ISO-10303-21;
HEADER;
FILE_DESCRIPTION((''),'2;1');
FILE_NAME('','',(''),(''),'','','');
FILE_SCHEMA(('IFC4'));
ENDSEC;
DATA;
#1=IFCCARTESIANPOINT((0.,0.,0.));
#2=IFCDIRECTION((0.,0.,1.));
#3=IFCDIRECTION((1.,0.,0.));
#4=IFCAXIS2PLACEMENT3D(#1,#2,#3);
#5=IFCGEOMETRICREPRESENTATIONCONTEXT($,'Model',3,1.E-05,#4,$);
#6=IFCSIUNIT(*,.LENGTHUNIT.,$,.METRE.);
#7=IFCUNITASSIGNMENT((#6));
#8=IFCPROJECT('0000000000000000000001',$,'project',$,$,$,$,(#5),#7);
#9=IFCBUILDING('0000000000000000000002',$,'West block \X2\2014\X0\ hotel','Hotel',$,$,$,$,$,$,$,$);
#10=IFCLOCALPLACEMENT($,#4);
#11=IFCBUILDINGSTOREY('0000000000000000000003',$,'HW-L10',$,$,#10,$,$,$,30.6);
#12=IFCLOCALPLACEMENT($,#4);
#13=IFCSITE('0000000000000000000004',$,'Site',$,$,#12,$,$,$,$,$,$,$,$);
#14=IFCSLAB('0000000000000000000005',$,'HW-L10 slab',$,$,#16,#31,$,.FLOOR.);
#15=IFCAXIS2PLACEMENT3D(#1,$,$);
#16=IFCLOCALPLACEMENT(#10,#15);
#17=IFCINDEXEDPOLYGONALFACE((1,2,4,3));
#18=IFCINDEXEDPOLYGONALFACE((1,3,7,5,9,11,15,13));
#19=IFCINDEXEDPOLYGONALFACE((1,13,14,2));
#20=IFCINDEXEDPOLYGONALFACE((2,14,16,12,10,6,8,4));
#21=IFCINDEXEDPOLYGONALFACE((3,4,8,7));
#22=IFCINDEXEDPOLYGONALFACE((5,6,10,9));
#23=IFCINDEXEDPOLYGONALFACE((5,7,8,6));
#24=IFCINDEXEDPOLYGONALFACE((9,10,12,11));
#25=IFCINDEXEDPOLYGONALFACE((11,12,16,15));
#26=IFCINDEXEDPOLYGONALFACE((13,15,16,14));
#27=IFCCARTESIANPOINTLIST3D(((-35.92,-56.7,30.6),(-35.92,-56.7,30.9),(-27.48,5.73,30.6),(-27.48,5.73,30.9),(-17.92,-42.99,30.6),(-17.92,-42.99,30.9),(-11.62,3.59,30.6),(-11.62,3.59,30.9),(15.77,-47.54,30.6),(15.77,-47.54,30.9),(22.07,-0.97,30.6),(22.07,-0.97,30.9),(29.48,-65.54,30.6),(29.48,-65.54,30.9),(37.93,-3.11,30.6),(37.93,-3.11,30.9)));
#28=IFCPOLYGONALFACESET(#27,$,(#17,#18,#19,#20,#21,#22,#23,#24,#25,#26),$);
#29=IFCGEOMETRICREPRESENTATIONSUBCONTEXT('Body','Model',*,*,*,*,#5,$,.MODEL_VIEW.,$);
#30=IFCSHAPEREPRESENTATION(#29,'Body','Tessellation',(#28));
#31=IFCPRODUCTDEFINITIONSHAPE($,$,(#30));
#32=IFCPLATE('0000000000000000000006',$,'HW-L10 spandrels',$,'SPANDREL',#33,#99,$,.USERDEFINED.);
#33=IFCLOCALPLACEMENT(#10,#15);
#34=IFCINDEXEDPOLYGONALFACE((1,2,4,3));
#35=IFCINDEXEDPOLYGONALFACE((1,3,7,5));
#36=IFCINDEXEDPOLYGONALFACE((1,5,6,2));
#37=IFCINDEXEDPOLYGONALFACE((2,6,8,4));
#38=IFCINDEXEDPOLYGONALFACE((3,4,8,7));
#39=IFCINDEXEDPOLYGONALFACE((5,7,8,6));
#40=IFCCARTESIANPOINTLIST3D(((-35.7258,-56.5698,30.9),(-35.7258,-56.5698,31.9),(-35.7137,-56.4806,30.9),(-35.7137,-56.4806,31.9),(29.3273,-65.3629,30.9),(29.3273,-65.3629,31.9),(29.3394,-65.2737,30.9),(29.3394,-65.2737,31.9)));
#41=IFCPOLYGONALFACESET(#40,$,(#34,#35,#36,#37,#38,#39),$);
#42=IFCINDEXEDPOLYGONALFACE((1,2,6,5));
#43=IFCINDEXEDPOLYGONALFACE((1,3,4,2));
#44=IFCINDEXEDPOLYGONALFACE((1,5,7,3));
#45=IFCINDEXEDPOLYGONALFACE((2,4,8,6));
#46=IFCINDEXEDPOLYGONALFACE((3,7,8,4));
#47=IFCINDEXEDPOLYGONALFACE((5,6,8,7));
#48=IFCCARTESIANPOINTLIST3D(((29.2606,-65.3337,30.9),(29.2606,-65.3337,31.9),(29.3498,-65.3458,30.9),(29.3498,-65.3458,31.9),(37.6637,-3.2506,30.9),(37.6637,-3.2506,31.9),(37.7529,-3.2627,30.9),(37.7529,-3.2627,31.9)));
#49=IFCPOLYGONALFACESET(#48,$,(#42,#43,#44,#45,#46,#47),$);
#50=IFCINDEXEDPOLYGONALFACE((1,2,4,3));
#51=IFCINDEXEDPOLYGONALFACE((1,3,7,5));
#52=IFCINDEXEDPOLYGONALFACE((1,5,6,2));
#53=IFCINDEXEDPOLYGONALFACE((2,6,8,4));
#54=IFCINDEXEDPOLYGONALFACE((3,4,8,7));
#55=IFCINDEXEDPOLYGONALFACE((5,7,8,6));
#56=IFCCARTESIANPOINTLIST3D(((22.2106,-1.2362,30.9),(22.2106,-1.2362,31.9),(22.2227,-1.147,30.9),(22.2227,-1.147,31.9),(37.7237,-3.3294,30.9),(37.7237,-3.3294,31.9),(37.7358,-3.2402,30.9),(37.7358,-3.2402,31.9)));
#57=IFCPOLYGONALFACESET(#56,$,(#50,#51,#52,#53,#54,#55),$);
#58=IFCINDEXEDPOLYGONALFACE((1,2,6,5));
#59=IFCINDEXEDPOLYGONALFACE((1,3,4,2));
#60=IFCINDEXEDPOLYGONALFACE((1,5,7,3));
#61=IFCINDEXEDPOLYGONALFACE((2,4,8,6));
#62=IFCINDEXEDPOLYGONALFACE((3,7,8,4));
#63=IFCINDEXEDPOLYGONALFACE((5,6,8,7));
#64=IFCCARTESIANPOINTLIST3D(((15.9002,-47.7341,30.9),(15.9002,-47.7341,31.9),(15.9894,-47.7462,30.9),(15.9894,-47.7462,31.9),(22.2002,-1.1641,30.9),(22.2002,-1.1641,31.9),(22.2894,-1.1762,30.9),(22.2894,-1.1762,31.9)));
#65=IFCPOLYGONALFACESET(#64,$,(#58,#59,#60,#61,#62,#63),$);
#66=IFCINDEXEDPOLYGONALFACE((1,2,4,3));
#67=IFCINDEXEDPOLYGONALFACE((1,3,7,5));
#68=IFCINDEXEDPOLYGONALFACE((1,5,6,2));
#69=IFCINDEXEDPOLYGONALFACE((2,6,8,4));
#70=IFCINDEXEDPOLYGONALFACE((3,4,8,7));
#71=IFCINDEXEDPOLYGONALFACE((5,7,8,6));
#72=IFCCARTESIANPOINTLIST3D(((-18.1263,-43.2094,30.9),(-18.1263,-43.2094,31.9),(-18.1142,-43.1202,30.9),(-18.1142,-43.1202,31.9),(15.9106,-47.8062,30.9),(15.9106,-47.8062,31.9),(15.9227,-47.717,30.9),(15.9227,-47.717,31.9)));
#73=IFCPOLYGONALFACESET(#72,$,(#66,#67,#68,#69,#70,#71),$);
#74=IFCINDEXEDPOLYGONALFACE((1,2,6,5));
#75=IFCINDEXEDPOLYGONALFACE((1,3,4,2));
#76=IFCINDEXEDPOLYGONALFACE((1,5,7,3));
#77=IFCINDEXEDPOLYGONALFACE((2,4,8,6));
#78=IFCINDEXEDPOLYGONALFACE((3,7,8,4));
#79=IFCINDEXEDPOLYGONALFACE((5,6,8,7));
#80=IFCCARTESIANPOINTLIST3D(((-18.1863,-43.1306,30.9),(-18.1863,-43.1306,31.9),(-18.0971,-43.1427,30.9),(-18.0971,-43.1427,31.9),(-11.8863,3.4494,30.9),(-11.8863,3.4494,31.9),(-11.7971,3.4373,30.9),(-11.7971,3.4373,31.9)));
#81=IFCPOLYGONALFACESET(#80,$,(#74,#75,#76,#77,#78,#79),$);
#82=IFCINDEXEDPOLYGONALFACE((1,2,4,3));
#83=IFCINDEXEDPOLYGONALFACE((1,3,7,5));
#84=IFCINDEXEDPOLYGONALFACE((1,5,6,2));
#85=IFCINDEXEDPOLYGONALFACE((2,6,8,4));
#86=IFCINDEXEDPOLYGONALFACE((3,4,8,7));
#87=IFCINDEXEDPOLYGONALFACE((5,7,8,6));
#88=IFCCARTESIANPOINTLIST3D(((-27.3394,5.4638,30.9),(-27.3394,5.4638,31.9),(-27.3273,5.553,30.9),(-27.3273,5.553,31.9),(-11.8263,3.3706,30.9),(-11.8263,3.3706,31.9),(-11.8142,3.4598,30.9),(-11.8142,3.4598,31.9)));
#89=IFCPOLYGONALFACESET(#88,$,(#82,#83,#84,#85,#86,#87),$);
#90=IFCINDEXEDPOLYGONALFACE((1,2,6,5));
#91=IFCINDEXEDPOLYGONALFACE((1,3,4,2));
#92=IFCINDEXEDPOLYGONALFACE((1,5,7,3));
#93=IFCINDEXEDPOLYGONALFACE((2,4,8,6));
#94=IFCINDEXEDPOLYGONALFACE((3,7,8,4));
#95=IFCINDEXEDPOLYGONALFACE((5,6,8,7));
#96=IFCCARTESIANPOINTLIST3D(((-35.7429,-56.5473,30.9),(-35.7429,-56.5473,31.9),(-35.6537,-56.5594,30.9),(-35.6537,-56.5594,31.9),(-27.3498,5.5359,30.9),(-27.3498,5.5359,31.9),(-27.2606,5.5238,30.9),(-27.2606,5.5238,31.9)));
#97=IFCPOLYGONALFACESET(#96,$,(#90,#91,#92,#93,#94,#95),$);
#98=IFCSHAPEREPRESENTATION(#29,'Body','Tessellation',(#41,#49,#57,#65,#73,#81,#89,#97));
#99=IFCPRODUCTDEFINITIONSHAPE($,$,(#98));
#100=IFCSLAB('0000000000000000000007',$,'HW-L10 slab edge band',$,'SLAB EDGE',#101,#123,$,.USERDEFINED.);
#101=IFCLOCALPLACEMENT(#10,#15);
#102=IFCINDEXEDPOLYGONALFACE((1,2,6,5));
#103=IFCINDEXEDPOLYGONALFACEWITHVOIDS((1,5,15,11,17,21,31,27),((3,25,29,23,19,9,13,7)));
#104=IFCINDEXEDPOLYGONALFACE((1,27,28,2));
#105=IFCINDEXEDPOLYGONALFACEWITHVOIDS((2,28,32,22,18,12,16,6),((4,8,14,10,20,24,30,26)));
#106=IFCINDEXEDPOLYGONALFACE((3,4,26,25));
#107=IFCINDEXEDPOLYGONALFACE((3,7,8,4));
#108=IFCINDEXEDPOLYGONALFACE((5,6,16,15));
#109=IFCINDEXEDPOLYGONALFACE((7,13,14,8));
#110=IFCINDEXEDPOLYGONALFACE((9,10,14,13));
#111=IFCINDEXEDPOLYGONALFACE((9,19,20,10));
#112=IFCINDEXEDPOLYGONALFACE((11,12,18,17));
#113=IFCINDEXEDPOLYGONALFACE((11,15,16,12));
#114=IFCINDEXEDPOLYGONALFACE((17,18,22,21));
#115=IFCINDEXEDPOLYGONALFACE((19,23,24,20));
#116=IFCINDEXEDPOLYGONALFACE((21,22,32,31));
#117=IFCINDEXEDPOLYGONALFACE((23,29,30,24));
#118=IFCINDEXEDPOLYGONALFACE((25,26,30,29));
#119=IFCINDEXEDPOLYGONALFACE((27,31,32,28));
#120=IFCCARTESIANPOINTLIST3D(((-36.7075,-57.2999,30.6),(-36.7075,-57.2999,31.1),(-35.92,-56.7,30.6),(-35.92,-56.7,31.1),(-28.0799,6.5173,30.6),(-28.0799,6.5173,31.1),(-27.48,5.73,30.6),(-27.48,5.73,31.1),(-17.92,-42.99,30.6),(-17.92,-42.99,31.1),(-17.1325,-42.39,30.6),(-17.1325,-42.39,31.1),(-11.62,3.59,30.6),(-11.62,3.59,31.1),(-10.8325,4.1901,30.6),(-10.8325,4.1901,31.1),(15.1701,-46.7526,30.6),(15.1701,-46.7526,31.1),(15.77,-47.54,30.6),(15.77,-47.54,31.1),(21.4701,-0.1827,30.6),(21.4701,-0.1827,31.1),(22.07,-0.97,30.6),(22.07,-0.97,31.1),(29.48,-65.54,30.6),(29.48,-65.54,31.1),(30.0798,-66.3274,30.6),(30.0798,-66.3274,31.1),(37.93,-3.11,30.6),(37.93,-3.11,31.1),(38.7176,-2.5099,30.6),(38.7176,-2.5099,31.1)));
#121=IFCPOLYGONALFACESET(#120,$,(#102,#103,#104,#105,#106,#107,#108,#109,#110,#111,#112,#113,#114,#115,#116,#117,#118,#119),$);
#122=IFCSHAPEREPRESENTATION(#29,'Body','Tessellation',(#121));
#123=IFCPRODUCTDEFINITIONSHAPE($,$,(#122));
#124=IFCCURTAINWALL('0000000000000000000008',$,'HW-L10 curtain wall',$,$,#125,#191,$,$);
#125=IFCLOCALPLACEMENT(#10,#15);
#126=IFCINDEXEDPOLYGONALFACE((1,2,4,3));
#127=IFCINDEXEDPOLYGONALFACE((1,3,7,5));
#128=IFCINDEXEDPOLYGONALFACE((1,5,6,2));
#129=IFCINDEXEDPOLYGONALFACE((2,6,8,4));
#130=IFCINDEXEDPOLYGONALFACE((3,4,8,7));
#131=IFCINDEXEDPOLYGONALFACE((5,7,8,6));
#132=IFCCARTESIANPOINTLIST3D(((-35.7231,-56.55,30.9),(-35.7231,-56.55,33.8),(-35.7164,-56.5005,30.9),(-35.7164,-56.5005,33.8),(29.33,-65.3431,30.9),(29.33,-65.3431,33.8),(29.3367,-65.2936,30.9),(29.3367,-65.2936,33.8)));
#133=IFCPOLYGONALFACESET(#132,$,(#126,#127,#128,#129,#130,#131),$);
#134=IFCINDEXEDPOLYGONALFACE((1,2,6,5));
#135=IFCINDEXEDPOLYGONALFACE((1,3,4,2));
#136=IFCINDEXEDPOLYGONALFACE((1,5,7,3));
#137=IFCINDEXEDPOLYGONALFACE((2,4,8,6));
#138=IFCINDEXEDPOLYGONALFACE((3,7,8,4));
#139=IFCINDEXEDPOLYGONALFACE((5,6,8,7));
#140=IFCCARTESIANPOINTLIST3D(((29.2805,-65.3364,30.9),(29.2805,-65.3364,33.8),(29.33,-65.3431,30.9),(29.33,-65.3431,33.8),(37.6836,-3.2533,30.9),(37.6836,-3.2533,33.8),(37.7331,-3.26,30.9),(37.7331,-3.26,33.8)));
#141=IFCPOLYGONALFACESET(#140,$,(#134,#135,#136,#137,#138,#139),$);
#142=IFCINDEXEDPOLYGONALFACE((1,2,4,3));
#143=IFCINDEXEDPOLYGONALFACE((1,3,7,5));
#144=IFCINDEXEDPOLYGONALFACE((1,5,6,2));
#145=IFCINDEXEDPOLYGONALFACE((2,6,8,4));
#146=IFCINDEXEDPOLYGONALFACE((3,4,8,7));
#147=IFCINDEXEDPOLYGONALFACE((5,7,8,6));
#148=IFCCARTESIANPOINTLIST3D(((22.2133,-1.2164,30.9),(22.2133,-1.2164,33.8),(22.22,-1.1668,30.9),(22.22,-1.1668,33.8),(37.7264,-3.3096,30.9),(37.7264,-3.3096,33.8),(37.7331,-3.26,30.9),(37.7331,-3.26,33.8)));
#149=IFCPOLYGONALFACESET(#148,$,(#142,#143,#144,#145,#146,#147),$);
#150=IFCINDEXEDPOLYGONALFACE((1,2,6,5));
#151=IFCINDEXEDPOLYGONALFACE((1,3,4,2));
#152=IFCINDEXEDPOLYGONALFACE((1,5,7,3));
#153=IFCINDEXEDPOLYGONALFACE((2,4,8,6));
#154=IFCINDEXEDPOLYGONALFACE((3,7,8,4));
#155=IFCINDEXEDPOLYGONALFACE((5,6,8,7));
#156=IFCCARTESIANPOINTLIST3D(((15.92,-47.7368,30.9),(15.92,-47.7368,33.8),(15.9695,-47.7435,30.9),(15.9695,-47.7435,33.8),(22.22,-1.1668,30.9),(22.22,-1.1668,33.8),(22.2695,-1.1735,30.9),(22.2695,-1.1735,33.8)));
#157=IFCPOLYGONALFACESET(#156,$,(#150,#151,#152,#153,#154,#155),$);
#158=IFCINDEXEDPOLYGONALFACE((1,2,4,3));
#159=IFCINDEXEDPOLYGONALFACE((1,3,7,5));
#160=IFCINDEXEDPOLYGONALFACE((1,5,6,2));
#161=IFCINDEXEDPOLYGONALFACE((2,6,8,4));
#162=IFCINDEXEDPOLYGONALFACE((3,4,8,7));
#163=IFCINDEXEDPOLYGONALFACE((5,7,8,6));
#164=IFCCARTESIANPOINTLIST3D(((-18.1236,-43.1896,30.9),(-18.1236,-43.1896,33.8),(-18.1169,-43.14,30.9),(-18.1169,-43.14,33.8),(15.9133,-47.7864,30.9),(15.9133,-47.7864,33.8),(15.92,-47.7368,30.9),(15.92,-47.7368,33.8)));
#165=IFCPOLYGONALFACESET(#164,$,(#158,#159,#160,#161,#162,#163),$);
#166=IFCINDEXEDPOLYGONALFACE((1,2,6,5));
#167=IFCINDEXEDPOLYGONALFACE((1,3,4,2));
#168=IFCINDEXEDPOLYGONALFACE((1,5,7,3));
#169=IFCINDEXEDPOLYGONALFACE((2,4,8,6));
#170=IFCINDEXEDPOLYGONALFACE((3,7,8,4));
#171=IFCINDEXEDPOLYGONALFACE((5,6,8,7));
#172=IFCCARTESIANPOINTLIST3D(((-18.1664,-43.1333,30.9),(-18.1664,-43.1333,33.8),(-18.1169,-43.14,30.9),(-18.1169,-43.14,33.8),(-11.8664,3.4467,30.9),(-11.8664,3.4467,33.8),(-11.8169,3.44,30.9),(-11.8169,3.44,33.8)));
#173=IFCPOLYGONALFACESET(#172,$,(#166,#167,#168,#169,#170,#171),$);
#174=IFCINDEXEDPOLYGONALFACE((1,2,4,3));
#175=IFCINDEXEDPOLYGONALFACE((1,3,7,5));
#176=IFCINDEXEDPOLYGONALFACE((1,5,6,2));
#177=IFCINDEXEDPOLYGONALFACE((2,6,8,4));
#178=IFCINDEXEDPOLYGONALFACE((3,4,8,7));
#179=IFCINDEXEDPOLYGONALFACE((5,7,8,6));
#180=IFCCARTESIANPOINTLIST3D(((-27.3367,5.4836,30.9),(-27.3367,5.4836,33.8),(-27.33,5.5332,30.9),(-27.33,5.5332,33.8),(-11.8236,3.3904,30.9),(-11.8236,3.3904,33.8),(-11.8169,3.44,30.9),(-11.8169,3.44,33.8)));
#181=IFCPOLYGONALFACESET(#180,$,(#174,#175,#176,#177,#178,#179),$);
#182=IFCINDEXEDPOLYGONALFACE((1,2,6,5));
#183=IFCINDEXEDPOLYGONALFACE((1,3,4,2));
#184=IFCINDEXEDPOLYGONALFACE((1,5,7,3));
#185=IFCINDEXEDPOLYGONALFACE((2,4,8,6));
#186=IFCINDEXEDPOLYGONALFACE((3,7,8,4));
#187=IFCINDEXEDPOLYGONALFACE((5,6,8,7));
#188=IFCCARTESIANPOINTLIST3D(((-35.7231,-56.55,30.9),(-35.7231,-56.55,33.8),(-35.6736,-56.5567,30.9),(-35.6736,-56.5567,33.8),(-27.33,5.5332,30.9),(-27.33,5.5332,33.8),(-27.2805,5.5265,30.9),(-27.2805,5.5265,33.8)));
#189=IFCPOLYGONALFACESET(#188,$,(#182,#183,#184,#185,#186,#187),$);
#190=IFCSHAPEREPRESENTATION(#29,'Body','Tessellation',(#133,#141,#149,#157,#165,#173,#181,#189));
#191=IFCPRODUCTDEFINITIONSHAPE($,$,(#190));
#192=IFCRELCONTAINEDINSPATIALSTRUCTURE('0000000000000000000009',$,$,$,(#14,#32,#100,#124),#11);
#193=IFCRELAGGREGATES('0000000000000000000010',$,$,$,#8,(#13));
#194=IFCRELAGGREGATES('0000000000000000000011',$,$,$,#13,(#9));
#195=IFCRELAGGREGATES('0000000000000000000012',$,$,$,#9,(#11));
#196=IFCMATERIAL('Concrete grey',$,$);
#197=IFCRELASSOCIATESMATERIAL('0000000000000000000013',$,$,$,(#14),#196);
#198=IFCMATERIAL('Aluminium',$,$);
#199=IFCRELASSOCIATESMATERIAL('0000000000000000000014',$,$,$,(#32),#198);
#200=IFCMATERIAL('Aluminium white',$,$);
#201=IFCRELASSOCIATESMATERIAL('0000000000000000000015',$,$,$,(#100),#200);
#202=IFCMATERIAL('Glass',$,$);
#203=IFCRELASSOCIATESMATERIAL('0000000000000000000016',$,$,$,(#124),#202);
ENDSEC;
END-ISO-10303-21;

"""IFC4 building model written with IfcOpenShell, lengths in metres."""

from ifc_helpers import new_model, si_unit, frame, origin_with_axes, place, context, subcontext, project, spatial, polyline, outline, extrude, material, element, save


model = new_model("IFC4")

# Units and contexts
model_context = context("Model", 3, precision=1e-05, world=origin_with_axes())
body_context = subcontext(model_context, "Body", "Model", "MODEL_VIEW")
ifc_project = project(units=[si_unit("LENGTHUNIT", "METRE")], contexts=[model_context])

# Site, building, storey
site_placement = place(None, origin_with_axes())
site = spatial("IfcSite", under=ifc_project, at=site_placement, Name="Site")
building = spatial("IfcBuilding", under=site, Name="West block — hotel", Description="Hotel")
storey_placement = place(None, origin_with_axes())
storey = spatial("IfcBuildingStorey", under=building, at=storey_placement, Name="HW-L10", Elevation=30.6)

# Shared definitions
ifc_material_1 = material(Name="Aluminium")

# Slab
ifc_material_2 = material(Name="Concrete grey")
slab_1_placement = place(storey_placement, origin_with_axes())
element("IfcSlab", 1, at=slab_1_placement, inside=storey, material=ifc_material_2, Name="HW-L10 slab", PredefinedType="FLOOR", context=body_context, shape_type="SweptSolid", body=[
    extrude(outline(polyline([(-35.92, -56.7), (29.48, -65.54), (37.93, -3.11), (22.07, -0.97), (15.77, -47.54), (-17.92, -42.99), (-11.62, 3.59), (-27.48, 5.73), (-35.92, -56.7)])), frame((0.0, 0.0, 30.6), z_axis=(0.0, 0.0, 1.0), x_axis=(1.0, 0.0, 0.0)), (0.0, 0.0, 1.0), 0.3),
])

# Plate
plate_placement = place(storey_placement, origin_with_axes())
element("IfcPlate", 2, at=plate_placement, inside=storey, material=ifc_material_1, Name="HW-L10 spandrels", ObjectType="SPANDREL", PredefinedType="USERDEFINED", context=body_context, shape_type="SweptSolid", body=[
    extrude(outline(polyline([(-35.7258, -56.5698), (29.3273, -65.3629), (29.3394, -65.2737), (-35.7137, -56.4806), (-35.7258, -56.5698)])), frame((0.0, 0.0, 30.9), z_axis=(0.0, 0.0, 1.0), x_axis=(1.0, 0.0, 0.0)), (0.0, 0.0, 1.0), 1.0),
    extrude(outline(polyline([(29.3498, -65.3458), (37.7529, -3.2627), (37.6637, -3.2506), (29.2606, -65.3337), (29.3498, -65.3458)])), frame((0.0, 0.0, 30.9), z_axis=(0.0, 0.0, 1.0), x_axis=(1.0, 0.0, 0.0)), (0.0, 0.0, 1.0), 1.0),
    extrude(outline(polyline([(37.7358, -3.2402), (22.2227, -1.147), (22.2106, -1.2362), (37.7237, -3.3294), (37.7358, -3.2402)])), frame((0.0, 0.0, 30.9), z_axis=(0.0, 0.0, 1.0), x_axis=(1.0, 0.0, 0.0)), (0.0, 0.0, 1.0), 1.0),
    extrude(outline(polyline([(22.2002, -1.1641), (15.9002, -47.7341), (15.9894, -47.7462), (22.2894, -1.1762), (22.2002, -1.1641)])), frame((0.0, 0.0, 30.9), z_axis=(0.0, 0.0, 1.0), x_axis=(1.0, 0.0, 0.0)), (0.0, 0.0, 1.0), 1.0),
    extrude(outline(polyline([(15.9227, -47.717), (-18.1142, -43.1202), (-18.1263, -43.2094), (15.9106, -47.8062), (15.9227, -47.717)])), frame((0.0, 0.0, 30.9), z_axis=(0.0, 0.0, 1.0), x_axis=(1.0, 0.0, 0.0)), (0.0, 0.0, 1.0), 1.0),
    extrude(outline(polyline([(-18.0971, -43.1427), (-11.7971, 3.4373), (-11.8863, 3.4494), (-18.1863, -43.1306), (-18.0971, -43.1427)])), frame((0.0, 0.0, 30.9), z_axis=(0.0, 0.0, 1.0), x_axis=(1.0, 0.0, 0.0)), (0.0, 0.0, 1.0), 1.0),
    extrude(outline(polyline([(-11.8142, 3.4598), (-27.3273, 5.553), (-27.3394, 5.4638), (-11.8263, 3.3706), (-11.8142, 3.4598)])), frame((0.0, 0.0, 30.9), z_axis=(0.0, 0.0, 1.0), x_axis=(1.0, 0.0, 0.0)), (0.0, 0.0, 1.0), 1.0),
    extrude(outline(polyline([(-27.3498, 5.5359), (-35.7429, -56.5473), (-35.6537, -56.5594), (-27.2606, 5.5238), (-27.3498, 5.5359)])), frame((0.0, 0.0, 30.9), z_axis=(0.0, 0.0, 1.0), x_axis=(1.0, 0.0, 0.0)), (0.0, 0.0, 1.0), 1.0),
])

# Slab
ifc_material_3 = material(Name="Aluminium white")
slab_2_placement = place(storey_placement, origin_with_axes())
element("IfcSlab", 3, at=slab_2_placement, inside=storey, material=ifc_material_3, Name="HW-L10 slab edge band", ObjectType="SLAB EDGE", PredefinedType="USERDEFINED", context=body_context, shape_type="SweptSolid", body=[
    extrude(outline(polyline([(-36.7075, -57.2999), (30.0798, -66.3274), (38.7176, -2.5099), (21.4701, -0.1827), (15.1701, -46.7526), (-17.1325, -42.39), (-10.8325, 4.1901), (-28.0799, 6.5173), (-36.7075, -57.2999)]), holes=[polyline([(-35.92, -56.7), (29.48, -65.54), (37.93, -3.11), (22.07, -0.97), (15.77, -47.54), (-17.92, -42.99), (-11.62, 3.59), (-27.48, 5.73), (-35.92, -56.7)])]), frame((0.0, 0.0, 30.6), z_axis=(0.0, 0.0, 1.0), x_axis=(1.0, 0.0, 0.0)), (0.0, 0.0, 1.0), 0.5),
])

# Curtain wall
ifc_material_4 = material(Name="Glass")
curtain_wall_placement = place(storey_placement, origin_with_axes())
element("IfcCurtainWall", 4, at=curtain_wall_placement, inside=storey, material=ifc_material_4, Name="HW-L10 curtain wall", context=body_context, shape_type="SweptSolid", body=[
    extrude(outline(polyline([(-35.7231, -56.55), (29.33, -65.3431), (29.3367, -65.2936), (-35.7164, -56.5005), (-35.7231, -56.55)])), frame((0.0, 0.0, 30.9), z_axis=(0.0, 0.0, 1.0), x_axis=(1.0, 0.0, 0.0)), (0.0, 0.0, 1.0), 2.9),
    extrude(outline(polyline([(29.33, -65.3431), (37.7331, -3.26), (37.6836, -3.2533), (29.2805, -65.3364), (29.33, -65.3431)])), frame((0.0, 0.0, 30.9), z_axis=(0.0, 0.0, 1.0), x_axis=(1.0, 0.0, 0.0)), (0.0, 0.0, 1.0), 2.9),
    extrude(outline(polyline([(37.7331, -3.26), (22.22, -1.1668), (22.2133, -1.2164), (37.7264, -3.3096), (37.7331, -3.26)])), frame((0.0, 0.0, 30.9), z_axis=(0.0, 0.0, 1.0), x_axis=(1.0, 0.0, 0.0)), (0.0, 0.0, 1.0), 2.9),
    extrude(outline(polyline([(22.22, -1.1668), (15.92, -47.7368), (15.9695, -47.7435), (22.2695, -1.1735), (22.22, -1.1668)])), frame((0.0, 0.0, 30.9), z_axis=(0.0, 0.0, 1.0), x_axis=(1.0, 0.0, 0.0)), (0.0, 0.0, 1.0), 2.9),
    extrude(outline(polyline([(15.92, -47.7368), (-18.1169, -43.14), (-18.1236, -43.1896), (15.9133, -47.7864), (15.92, -47.7368)])), frame((0.0, 0.0, 30.9), z_axis=(0.0, 0.0, 1.0), x_axis=(1.0, 0.0, 0.0)), (0.0, 0.0, 1.0), 2.9),
    extrude(outline(polyline([(-18.1169, -43.14), (-11.8169, 3.44), (-11.8664, 3.4467), (-18.1664, -43.1333), (-18.1169, -43.14)])), frame((0.0, 0.0, 30.9), z_axis=(0.0, 0.0, 1.0), x_axis=(1.0, 0.0, 0.0)), (0.0, 0.0, 1.0), 2.9),
    extrude(outline(polyline([(-11.8169, 3.44), (-27.33, 5.5332), (-27.3367, 5.4836), (-11.8236, 3.3904), (-11.8169, 3.44)])), frame((0.0, 0.0, 30.9), z_axis=(0.0, 0.0, 1.0), x_axis=(1.0, 0.0, 0.0)), (0.0, 0.0, 1.0), 2.9),
    extrude(outline(polyline([(-27.33, 5.5332), (-35.7231, -56.55), (-35.6736, -56.5567), (-27.2805, 5.5265), (-27.33, 5.5332)])), frame((0.0, 0.0, 30.9), z_axis=(0.0, 0.0, 1.0), x_axis=(1.0, 0.0, 0.0)), (0.0, 0.0, 1.0), 2.9),
])

save(model, "model.ifc")
